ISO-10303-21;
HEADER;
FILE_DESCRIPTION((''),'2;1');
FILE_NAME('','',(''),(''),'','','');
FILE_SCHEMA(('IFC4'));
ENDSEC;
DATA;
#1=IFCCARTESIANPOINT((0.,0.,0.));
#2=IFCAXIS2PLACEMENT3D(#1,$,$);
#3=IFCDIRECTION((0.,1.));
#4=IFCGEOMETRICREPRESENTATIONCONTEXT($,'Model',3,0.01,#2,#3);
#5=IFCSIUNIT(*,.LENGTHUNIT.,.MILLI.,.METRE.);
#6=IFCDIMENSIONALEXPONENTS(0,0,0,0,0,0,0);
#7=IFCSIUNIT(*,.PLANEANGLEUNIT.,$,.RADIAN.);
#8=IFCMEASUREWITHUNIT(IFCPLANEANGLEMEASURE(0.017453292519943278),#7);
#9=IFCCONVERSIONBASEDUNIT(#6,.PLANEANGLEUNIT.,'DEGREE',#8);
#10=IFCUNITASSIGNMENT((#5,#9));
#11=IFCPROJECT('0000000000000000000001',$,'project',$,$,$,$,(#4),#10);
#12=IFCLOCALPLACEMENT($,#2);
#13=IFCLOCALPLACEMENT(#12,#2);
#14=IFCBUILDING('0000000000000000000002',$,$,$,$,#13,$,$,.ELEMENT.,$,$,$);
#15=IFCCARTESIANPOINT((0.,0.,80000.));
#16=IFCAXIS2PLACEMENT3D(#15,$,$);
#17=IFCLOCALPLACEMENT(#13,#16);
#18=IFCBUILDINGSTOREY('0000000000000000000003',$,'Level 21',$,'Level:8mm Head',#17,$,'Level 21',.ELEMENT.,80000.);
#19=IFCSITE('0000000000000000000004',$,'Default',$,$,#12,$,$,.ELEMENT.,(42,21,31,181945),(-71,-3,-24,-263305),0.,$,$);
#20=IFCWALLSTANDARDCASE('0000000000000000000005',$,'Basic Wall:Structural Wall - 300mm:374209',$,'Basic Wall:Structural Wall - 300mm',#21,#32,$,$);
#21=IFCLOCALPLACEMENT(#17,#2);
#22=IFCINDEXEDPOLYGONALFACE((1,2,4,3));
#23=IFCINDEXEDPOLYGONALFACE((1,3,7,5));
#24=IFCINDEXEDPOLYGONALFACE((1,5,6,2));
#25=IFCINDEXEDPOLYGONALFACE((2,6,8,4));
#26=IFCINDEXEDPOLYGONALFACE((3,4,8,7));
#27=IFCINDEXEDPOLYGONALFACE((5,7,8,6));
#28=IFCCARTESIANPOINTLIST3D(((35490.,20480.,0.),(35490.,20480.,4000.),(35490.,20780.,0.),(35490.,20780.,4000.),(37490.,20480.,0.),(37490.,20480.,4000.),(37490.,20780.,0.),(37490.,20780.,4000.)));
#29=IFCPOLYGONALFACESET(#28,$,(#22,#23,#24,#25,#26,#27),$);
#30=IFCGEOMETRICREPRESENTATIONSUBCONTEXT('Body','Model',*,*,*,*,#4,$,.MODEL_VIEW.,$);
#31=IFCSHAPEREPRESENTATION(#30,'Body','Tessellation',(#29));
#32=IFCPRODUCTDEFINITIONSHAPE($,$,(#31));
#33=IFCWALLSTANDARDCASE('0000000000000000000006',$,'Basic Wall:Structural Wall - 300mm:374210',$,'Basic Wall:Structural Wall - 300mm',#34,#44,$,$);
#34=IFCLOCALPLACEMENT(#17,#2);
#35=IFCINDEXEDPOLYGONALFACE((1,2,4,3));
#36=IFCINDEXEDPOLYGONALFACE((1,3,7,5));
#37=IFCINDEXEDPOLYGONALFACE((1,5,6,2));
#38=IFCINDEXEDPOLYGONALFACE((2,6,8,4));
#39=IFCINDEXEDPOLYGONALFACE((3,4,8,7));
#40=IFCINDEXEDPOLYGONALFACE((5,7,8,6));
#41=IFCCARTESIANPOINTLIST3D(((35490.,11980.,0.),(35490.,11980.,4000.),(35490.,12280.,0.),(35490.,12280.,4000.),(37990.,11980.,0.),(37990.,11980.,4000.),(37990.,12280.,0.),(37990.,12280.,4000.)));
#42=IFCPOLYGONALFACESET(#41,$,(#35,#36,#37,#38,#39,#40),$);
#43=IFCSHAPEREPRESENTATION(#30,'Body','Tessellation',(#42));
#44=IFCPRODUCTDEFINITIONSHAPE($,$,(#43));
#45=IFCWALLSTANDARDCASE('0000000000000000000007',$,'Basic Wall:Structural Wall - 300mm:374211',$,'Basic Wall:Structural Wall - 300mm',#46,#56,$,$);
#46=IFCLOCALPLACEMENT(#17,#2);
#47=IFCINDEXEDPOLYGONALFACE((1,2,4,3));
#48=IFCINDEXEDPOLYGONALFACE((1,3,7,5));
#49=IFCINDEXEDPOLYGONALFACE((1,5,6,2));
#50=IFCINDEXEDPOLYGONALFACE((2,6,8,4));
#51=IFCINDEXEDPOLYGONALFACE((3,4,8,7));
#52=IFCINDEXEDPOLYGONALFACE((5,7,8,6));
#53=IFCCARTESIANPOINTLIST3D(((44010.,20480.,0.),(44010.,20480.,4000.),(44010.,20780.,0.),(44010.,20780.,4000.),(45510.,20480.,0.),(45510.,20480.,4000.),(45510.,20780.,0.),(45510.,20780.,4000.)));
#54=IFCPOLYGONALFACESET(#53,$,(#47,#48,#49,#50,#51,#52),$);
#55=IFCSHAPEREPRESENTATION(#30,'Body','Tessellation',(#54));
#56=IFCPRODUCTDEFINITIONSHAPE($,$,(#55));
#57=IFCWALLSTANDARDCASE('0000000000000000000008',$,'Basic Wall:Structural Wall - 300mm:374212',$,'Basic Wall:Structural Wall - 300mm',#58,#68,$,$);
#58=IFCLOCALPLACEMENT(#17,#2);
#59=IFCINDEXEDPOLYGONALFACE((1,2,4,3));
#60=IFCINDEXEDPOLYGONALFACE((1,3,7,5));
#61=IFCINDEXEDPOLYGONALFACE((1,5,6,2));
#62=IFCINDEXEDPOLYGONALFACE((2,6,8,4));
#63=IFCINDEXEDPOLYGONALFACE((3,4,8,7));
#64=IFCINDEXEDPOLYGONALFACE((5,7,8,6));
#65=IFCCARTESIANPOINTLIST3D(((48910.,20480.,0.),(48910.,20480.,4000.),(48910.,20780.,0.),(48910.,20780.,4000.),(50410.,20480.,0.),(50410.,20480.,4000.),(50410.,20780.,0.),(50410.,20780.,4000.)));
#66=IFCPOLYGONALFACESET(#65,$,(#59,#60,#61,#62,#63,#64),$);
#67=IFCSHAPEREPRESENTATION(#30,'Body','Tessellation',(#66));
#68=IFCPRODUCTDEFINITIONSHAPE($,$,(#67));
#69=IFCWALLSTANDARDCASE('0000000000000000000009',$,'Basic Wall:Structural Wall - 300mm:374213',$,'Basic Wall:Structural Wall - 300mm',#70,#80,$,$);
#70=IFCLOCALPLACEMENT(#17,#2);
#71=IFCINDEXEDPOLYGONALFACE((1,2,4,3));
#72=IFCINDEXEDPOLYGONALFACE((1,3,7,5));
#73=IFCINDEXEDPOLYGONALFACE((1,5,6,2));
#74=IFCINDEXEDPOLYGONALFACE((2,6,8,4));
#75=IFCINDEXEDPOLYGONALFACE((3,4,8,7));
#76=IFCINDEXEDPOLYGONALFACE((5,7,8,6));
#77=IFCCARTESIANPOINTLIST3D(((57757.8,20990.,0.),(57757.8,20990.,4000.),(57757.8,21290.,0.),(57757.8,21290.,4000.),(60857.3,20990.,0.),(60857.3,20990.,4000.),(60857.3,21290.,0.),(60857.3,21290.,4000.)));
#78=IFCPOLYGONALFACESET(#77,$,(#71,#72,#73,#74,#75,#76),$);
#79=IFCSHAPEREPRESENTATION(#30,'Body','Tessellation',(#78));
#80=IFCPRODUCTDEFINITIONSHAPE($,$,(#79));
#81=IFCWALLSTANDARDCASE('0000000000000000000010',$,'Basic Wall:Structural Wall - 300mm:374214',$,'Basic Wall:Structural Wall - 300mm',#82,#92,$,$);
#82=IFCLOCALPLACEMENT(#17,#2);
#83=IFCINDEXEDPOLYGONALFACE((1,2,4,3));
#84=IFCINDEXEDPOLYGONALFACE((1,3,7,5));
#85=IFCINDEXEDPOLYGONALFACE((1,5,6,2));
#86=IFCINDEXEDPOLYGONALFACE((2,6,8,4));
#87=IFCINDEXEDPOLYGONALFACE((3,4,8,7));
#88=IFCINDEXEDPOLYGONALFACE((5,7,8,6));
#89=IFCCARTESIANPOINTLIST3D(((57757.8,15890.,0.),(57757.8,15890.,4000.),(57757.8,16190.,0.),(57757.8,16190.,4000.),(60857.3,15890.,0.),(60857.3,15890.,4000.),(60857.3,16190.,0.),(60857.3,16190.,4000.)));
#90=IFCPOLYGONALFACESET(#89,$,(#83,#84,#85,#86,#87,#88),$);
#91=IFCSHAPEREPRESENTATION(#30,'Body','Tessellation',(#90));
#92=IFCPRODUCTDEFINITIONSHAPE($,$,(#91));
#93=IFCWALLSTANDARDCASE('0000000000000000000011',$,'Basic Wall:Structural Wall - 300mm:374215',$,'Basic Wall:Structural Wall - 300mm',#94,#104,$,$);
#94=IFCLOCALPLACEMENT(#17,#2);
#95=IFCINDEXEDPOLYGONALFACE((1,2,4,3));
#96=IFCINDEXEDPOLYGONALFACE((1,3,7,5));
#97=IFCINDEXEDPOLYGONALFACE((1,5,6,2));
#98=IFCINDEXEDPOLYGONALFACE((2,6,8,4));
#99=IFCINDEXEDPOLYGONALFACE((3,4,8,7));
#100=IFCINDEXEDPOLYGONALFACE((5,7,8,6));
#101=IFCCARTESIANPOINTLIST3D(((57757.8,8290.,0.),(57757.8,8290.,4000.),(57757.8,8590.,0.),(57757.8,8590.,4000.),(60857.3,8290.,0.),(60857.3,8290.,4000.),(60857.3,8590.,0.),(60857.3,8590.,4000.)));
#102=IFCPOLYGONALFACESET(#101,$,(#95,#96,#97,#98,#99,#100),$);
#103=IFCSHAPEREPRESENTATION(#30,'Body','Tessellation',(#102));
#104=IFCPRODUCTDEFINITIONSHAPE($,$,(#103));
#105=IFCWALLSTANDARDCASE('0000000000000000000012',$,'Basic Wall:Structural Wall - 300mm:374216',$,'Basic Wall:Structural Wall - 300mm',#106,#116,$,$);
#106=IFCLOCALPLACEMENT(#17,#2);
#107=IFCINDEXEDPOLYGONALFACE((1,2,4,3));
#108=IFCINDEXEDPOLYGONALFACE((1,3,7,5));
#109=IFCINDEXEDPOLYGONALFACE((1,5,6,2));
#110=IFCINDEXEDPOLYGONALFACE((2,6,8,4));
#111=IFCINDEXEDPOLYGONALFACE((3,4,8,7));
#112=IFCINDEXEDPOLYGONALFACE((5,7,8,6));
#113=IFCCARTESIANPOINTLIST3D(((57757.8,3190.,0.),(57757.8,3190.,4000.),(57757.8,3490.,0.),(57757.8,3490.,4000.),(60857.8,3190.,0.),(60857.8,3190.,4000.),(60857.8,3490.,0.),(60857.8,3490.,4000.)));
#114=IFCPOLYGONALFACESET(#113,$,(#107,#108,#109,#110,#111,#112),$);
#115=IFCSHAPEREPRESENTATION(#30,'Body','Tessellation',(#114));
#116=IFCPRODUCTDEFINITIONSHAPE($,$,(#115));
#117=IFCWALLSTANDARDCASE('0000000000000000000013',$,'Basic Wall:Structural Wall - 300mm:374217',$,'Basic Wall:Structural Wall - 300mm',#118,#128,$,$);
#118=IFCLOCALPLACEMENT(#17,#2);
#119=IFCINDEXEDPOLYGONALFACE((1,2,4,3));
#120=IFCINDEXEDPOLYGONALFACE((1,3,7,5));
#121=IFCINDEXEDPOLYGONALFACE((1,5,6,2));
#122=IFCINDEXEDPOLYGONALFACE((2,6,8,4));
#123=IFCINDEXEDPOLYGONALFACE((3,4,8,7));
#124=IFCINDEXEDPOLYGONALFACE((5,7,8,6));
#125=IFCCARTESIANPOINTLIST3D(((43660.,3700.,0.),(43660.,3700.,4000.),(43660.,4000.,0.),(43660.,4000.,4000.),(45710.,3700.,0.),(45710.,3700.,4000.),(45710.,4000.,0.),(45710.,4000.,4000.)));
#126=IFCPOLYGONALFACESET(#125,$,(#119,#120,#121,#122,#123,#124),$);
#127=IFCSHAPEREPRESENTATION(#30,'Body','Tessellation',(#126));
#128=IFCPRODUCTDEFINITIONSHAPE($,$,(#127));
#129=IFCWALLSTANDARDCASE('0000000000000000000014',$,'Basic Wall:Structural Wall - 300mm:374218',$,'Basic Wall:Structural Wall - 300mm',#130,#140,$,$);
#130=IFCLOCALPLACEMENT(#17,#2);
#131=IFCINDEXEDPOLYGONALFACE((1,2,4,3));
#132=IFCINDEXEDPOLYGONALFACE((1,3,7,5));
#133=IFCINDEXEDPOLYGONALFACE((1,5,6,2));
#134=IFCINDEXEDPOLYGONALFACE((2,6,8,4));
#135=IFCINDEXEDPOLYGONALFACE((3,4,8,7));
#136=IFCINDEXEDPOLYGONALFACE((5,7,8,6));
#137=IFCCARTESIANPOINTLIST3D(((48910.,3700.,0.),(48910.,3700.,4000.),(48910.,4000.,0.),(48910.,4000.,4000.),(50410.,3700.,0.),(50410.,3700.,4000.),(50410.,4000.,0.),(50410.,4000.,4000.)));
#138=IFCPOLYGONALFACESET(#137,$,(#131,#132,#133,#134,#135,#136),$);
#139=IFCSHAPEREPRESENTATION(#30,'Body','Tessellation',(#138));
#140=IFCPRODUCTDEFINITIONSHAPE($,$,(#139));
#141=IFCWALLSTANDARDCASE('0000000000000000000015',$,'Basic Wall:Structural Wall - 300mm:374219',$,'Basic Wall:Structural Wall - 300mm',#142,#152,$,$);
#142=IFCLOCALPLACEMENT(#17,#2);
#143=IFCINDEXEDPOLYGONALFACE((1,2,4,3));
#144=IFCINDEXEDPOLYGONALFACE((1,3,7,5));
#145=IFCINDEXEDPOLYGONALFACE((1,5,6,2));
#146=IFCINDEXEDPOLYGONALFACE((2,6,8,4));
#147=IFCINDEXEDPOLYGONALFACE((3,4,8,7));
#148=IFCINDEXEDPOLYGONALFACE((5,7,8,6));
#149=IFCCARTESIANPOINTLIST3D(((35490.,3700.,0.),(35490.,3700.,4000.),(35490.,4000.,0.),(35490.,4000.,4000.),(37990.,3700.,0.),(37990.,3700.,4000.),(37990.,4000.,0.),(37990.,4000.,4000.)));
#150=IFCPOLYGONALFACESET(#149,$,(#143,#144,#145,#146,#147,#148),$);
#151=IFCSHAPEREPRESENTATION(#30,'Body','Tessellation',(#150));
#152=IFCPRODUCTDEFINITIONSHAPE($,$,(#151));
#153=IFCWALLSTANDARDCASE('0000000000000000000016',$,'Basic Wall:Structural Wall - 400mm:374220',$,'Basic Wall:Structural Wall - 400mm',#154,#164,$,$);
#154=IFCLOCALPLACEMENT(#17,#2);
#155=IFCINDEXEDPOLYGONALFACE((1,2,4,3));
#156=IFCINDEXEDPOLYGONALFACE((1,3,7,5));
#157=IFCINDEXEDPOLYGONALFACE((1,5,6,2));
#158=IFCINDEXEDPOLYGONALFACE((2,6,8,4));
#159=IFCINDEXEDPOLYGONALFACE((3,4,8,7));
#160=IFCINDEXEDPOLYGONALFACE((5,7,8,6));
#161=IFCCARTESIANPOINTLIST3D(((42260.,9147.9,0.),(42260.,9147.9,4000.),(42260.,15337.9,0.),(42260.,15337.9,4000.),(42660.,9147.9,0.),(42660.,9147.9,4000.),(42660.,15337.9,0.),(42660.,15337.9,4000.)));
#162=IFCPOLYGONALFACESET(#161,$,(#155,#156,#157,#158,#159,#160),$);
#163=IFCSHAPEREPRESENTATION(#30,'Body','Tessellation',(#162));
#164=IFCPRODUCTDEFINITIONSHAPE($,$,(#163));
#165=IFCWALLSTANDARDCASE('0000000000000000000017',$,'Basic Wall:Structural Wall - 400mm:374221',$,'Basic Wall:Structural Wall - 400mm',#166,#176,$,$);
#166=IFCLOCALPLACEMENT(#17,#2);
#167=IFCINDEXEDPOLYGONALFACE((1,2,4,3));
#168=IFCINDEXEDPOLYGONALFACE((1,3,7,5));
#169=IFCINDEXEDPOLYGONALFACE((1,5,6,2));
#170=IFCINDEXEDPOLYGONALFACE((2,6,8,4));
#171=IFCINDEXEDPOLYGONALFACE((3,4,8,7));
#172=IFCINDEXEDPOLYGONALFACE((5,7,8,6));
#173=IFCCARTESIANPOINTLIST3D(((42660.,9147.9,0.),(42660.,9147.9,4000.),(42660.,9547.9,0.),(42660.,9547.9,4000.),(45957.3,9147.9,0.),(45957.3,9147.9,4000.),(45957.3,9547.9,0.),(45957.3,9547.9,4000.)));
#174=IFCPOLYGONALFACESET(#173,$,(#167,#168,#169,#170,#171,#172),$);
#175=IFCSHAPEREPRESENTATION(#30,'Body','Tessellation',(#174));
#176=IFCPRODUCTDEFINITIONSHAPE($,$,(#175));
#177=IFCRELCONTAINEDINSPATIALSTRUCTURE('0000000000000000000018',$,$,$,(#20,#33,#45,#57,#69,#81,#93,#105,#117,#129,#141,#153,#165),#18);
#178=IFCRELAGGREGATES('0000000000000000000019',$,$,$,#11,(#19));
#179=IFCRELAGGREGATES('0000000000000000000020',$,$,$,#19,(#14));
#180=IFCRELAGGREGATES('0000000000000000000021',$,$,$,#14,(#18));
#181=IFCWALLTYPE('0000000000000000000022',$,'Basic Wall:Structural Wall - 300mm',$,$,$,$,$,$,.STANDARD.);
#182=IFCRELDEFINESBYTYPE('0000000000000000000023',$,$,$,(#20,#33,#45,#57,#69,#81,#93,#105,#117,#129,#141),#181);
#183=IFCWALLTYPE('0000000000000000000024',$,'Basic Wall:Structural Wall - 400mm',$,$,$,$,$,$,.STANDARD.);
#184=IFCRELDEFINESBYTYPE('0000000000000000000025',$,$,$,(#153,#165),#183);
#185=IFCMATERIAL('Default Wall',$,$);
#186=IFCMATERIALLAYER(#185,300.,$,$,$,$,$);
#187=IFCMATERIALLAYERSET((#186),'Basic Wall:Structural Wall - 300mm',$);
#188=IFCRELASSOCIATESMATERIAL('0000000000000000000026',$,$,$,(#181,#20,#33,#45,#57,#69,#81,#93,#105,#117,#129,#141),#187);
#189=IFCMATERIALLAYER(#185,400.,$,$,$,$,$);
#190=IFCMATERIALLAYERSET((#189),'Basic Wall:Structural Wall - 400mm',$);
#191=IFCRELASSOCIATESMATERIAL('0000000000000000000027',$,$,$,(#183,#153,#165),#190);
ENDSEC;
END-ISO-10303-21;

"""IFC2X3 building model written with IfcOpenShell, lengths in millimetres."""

from ifc_helpers import new_model, entity, si_unit, converted_unit, direction, frame, frame_2d, origin, place, context, subcontext, project, spatial, rectangle, extrude, material, layer, layer_set, layer_usage, type_object, element, save


model = new_model("IFC2X3")

# Units and contexts
model_context = context("Model", 3, precision=0.01, world=origin(), true_north=direction((0.0, 1.0)))
body_context = subcontext(model_context, "Body", "Model", "MODEL_VIEW")
ifc_project = project(units=[si_unit("LENGTHUNIT", "METRE", prefix="MILLI"), converted_unit("PLANEANGLEUNIT", "DEGREE", entity("IfcPlaneAngleMeasure", 0.017453292519943278), si_unit("PLANEANGLEUNIT", "RADIAN"), dimensions=[0, 0, 0, 0, 0, 0, 0])], contexts=[model_context])

# Site, building, storey
site_placement = place(None, origin())
site = spatial("IfcSite", under=ifc_project, at=site_placement, Name="Default", CompositionType="ELEMENT", RefLatitude=(42, 21, 31, 181945), RefLongitude=(-71, -3, -24, -263305), RefElevation=0.0)
building_placement = place(site_placement, origin())
building = spatial("IfcBuilding", under=site, at=building_placement, CompositionType="ELEMENT")
storey_placement = place(building_placement, frame((0.0, 0.0, 80000.0)))
storey = spatial("IfcBuildingStorey", under=building, at=storey_placement, Name="Level 21", ObjectType="Level:8mm Head", LongName="Level 21", CompositionType="ELEMENT", Elevation=80000.0)

# Walls
ifc_material_1 = material(Name="Default Wall")
ifc_layer_1 = layer(ifc_material_1, 300.0)
ifc_layer_set_1 = layer_set([ifc_layer_1], Name="Basic Wall:Structural Wall - 300mm")
ifc_layer_usage_1 = layer_usage(ifc_layer_set_1, "AXIS2", "NEGATIVE", 150.0)
wall_type_1 = type_object("IfcWallType", Name="Basic Wall:Structural Wall - 300mm", PredefinedType="STANDARD", material=ifc_layer_set_1)
wall_1_placement = place(storey_placement, frame((35490.0, 20630.0, 0.0)))
element("IfcWallStandardCase", 1, at=wall_1_placement, inside=storey, type_object=wall_type_1, material=ifc_layer_usage_1, Name="Basic Wall:Structural Wall - 300mm:374209", ObjectType="Basic Wall:Structural Wall - 300mm", context=body_context, shape_type="SweptSolid", body=[
    extrude(rectangle(XDim=2000.0, YDim=300.0, at=frame_2d((1000.0, 0.0), x_axis=(-1.0, 0.0))), origin(), (0.0, 0.0, 1.0), 4000.0),
])
ifc_layer_usage_2 = layer_usage(ifc_layer_set_1, "AXIS2", "POSITIVE", -150.0)
wall_2_placement = place(storey_placement, frame((35490.0, 12130.0, 0.0)))
element("IfcWallStandardCase", 2, at=wall_2_placement, inside=storey, type_object=wall_type_1, material=ifc_layer_usage_2, Name="Basic Wall:Structural Wall - 300mm:374210", ObjectType="Basic Wall:Structural Wall - 300mm", context=body_context, shape_type="SweptSolid", body=[
    extrude(rectangle(XDim=2500.0, YDim=300.0, at=frame_2d((1250.0, 0.0), x_axis=(-1.0, 0.0))), origin(), (0.0, 0.0, 1.0), 4000.0),
])
ifc_layer_usage_3 = layer_usage(ifc_layer_set_1, "AXIS2", "NEGATIVE", 150.0)
wall_3_placement = place(storey_placement, frame((44010.0, 20630.0, 0.0)))
element("IfcWallStandardCase", 3, at=wall_3_placement, inside=storey, type_object=wall_type_1, material=ifc_layer_usage_3, Name="Basic Wall:Structural Wall - 300mm:374211", ObjectType="Basic Wall:Structural Wall - 300mm", context=body_context, shape_type="SweptSolid", body=[
    extrude(rectangle(XDim=1500.0, YDim=300.0, at=frame_2d((750.0, 0.0), x_axis=(-1.0, 0.0))), origin(), (0.0, 0.0, 1.0), 4000.0),
])
ifc_layer_usage_4 = layer_usage(ifc_layer_set_1, "AXIS2", "NEGATIVE", 150.0)
wall_4_placement = place(storey_placement, frame((48910.0, 20630.0, 0.0)))
element("IfcWallStandardCase", 4, at=wall_4_placement, inside=storey, type_object=wall_type_1, material=ifc_layer_usage_4, Name="Basic Wall:Structural Wall - 300mm:374212", ObjectType="Basic Wall:Structural Wall - 300mm", context=body_context, shape_type="SweptSolid", body=[
    extrude(rectangle(XDim=1500.0, YDim=300.0, at=frame_2d((750.0, 0.0), x_axis=(-1.0, 0.0))), origin(), (0.0, 0.0, 1.0), 4000.0),
])
ifc_layer_usage_5 = layer_usage(ifc_layer_set_1, "AXIS2", "NEGATIVE", 150.0)
wall_5_placement = place(storey_placement, frame((57757.8, 21140.0, 0.0)))
element("IfcWallStandardCase", 5, at=wall_5_placement, inside=storey, type_object=wall_type_1, material=ifc_layer_usage_5, Name="Basic Wall:Structural Wall - 300mm:374213", ObjectType="Basic Wall:Structural Wall - 300mm", context=body_context, shape_type="SweptSolid", body=[
    extrude(rectangle(XDim=3099.5, YDim=300.0, at=frame_2d((1549.8, 0.0), x_axis=(-1.0, 0.0))), origin(), (0.0, 0.0, 1.0), 4000.0),
])
ifc_layer_usage_6 = layer_usage(ifc_layer_set_1, "AXIS2", "NEGATIVE", 150.0)
wall_6_placement = place(storey_placement, frame((57757.8, 16040.0, 0.0)))
element("IfcWallStandardCase", 6, at=wall_6_placement, inside=storey, type_object=wall_type_1, material=ifc_layer_usage_6, Name="Basic Wall:Structural Wall - 300mm:374214", ObjectType="Basic Wall:Structural Wall - 300mm", context=body_context, shape_type="SweptSolid", body=[
    extrude(rectangle(XDim=3099.5, YDim=300.0, at=frame_2d((1549.8, 0.0), x_axis=(-1.0, 0.0))), origin(), (0.0, 0.0, 1.0), 4000.0),
])
ifc_layer_usage_7 = layer_usage(ifc_layer_set_1, "AXIS2", "POSITIVE", -150.0)
wall_7_placement = place(storey_placement, frame((57757.8, 8440.0, 0.0)))
element("IfcWallStandardCase", 7, at=wall_7_placement, inside=storey, type_object=wall_type_1, material=ifc_layer_usage_7, Name="Basic Wall:Structural Wall - 300mm:374215", ObjectType="Basic Wall:Structural Wall - 300mm", context=body_context, shape_type="SweptSolid", body=[
    extrude(rectangle(XDim=3099.5, YDim=300.0, at=frame_2d((1549.8, 0.0), x_axis=(-1.0, 0.0))), origin(), (0.0, 0.0, 1.0), 4000.0),
])
ifc_layer_usage_8 = layer_usage(ifc_layer_set_1, "AXIS2", "POSITIVE", -150.0)
wall_8_placement = place(storey_placement, frame((57757.8, 3340.0, 0.0)))
element("IfcWallStandardCase", 8, at=wall_8_placement, inside=storey, type_object=wall_type_1, material=ifc_layer_usage_8, Name="Basic Wall:Structural Wall - 300mm:374216", ObjectType="Basic Wall:Structural Wall - 300mm", context=body_context, shape_type="SweptSolid", body=[
    extrude(rectangle(XDim=3100.0, YDim=300.0, at=frame_2d((1550.0, 0.0), x_axis=(-1.0, 0.0))), origin(), (0.0, 0.0, 1.0), 4000.0),
])
ifc_layer_usage_9 = layer_usage(ifc_layer_set_1, "AXIS2", "POSITIVE", -150.0)
wall_9_placement = place(storey_placement, frame((43660.0, 3850.0, 0.0)))
element("IfcWallStandardCase", 9, at=wall_9_placement, inside=storey, type_object=wall_type_1, material=ifc_layer_usage_9, Name="Basic Wall:Structural Wall - 300mm:374217", ObjectType="Basic Wall:Structural Wall - 300mm", context=body_context, shape_type="SweptSolid", body=[
    extrude(rectangle(XDim=2050.0, YDim=300.0, at=frame_2d((1025.0, 0.0), x_axis=(-1.0, 0.0))), origin(), (0.0, 0.0, 1.0), 4000.0),
])
ifc_layer_usage_10 = layer_usage(ifc_layer_set_1, "AXIS2", "POSITIVE", -150.0)
wall_10_placement = place(storey_placement, frame((48910.0, 3850.0, 0.0)))
element("IfcWallStandardCase", 10, at=wall_10_placement, inside=storey, type_object=wall_type_1, material=ifc_layer_usage_10, Name="Basic Wall:Structural Wall - 300mm:374218", ObjectType="Basic Wall:Structural Wall - 300mm", context=body_context, shape_type="SweptSolid", body=[
    extrude(rectangle(XDim=1500.0, YDim=300.0, at=frame_2d((750.0, 0.0), x_axis=(-1.0, 0.0))), origin(), (0.0, 0.0, 1.0), 4000.0),
])
ifc_layer_usage_11 = layer_usage(ifc_layer_set_1, "AXIS2", "POSITIVE", -150.0)
wall_11_placement = place(storey_placement, frame((35490.0, 3850.0, 0.0)))
element("IfcWallStandardCase", 11, at=wall_11_placement, inside=storey, type_object=wall_type_1, material=ifc_layer_usage_11, Name="Basic Wall:Structural Wall - 300mm:374219", ObjectType="Basic Wall:Structural Wall - 300mm", context=body_context, shape_type="SweptSolid", body=[
    extrude(rectangle(XDim=2500.0, YDim=300.0, at=frame_2d((1250.0, 0.0), x_axis=(-1.0, 0.0))), origin(), (0.0, 0.0, 1.0), 4000.0),
])
ifc_layer_2 = layer(ifc_material_1, 400.0)
ifc_layer_set_2 = layer_set([ifc_layer_2], Name="Basic Wall:Structural Wall - 400mm")
ifc_layer_usage_12 = layer_usage(ifc_layer_set_2, "AXIS2", "POSITIVE", -200.0)
wall_type_2 = type_object("IfcWallType", Name="Basic Wall:Structural Wall - 400mm", PredefinedType="STANDARD", material=ifc_layer_set_2)
wall_12_placement = place(storey_placement, frame((42460.0, 15337.9, 0.0), z_axis=(0.0, 0.0, 1.0), x_axis=(0.0, -1.0, 0.0)))
element("IfcWallStandardCase", 12, at=wall_12_placement, inside=storey, type_object=wall_type_2, material=ifc_layer_usage_12, Name="Basic Wall:Structural Wall - 400mm:374220", ObjectType="Basic Wall:Structural Wall - 400mm", context=body_context, shape_type="SweptSolid", body=[
    extrude(rectangle(XDim=6190.0, YDim=400.0, at=frame_2d((3095.0, 0.0), x_axis=(-1.0, 0.0))), origin(), (0.0, 0.0, 1.0), 4000.0),
])
ifc_layer_usage_13 = layer_usage(ifc_layer_set_2, "AXIS2", "POSITIVE", -200.0)
wall_13_placement = place(storey_placement, frame((42660.0, 9347.9, 0.0)))
element("IfcWallStandardCase", 13, at=wall_13_placement, inside=storey, type_object=wall_type_2, material=ifc_layer_usage_13, Name="Basic Wall:Structural Wall - 400mm:374221", ObjectType="Basic Wall:Structural Wall - 400mm", context=body_context, shape_type="SweptSolid", body=[
    extrude(rectangle(XDim=3297.3, YDim=400.0, at=frame_2d((1648.6, 0.0), x_axis=(-1.0, 0.0))), origin(), (0.0, 0.0, 1.0), 4000.0),
])

save(model, "model.ifc")
